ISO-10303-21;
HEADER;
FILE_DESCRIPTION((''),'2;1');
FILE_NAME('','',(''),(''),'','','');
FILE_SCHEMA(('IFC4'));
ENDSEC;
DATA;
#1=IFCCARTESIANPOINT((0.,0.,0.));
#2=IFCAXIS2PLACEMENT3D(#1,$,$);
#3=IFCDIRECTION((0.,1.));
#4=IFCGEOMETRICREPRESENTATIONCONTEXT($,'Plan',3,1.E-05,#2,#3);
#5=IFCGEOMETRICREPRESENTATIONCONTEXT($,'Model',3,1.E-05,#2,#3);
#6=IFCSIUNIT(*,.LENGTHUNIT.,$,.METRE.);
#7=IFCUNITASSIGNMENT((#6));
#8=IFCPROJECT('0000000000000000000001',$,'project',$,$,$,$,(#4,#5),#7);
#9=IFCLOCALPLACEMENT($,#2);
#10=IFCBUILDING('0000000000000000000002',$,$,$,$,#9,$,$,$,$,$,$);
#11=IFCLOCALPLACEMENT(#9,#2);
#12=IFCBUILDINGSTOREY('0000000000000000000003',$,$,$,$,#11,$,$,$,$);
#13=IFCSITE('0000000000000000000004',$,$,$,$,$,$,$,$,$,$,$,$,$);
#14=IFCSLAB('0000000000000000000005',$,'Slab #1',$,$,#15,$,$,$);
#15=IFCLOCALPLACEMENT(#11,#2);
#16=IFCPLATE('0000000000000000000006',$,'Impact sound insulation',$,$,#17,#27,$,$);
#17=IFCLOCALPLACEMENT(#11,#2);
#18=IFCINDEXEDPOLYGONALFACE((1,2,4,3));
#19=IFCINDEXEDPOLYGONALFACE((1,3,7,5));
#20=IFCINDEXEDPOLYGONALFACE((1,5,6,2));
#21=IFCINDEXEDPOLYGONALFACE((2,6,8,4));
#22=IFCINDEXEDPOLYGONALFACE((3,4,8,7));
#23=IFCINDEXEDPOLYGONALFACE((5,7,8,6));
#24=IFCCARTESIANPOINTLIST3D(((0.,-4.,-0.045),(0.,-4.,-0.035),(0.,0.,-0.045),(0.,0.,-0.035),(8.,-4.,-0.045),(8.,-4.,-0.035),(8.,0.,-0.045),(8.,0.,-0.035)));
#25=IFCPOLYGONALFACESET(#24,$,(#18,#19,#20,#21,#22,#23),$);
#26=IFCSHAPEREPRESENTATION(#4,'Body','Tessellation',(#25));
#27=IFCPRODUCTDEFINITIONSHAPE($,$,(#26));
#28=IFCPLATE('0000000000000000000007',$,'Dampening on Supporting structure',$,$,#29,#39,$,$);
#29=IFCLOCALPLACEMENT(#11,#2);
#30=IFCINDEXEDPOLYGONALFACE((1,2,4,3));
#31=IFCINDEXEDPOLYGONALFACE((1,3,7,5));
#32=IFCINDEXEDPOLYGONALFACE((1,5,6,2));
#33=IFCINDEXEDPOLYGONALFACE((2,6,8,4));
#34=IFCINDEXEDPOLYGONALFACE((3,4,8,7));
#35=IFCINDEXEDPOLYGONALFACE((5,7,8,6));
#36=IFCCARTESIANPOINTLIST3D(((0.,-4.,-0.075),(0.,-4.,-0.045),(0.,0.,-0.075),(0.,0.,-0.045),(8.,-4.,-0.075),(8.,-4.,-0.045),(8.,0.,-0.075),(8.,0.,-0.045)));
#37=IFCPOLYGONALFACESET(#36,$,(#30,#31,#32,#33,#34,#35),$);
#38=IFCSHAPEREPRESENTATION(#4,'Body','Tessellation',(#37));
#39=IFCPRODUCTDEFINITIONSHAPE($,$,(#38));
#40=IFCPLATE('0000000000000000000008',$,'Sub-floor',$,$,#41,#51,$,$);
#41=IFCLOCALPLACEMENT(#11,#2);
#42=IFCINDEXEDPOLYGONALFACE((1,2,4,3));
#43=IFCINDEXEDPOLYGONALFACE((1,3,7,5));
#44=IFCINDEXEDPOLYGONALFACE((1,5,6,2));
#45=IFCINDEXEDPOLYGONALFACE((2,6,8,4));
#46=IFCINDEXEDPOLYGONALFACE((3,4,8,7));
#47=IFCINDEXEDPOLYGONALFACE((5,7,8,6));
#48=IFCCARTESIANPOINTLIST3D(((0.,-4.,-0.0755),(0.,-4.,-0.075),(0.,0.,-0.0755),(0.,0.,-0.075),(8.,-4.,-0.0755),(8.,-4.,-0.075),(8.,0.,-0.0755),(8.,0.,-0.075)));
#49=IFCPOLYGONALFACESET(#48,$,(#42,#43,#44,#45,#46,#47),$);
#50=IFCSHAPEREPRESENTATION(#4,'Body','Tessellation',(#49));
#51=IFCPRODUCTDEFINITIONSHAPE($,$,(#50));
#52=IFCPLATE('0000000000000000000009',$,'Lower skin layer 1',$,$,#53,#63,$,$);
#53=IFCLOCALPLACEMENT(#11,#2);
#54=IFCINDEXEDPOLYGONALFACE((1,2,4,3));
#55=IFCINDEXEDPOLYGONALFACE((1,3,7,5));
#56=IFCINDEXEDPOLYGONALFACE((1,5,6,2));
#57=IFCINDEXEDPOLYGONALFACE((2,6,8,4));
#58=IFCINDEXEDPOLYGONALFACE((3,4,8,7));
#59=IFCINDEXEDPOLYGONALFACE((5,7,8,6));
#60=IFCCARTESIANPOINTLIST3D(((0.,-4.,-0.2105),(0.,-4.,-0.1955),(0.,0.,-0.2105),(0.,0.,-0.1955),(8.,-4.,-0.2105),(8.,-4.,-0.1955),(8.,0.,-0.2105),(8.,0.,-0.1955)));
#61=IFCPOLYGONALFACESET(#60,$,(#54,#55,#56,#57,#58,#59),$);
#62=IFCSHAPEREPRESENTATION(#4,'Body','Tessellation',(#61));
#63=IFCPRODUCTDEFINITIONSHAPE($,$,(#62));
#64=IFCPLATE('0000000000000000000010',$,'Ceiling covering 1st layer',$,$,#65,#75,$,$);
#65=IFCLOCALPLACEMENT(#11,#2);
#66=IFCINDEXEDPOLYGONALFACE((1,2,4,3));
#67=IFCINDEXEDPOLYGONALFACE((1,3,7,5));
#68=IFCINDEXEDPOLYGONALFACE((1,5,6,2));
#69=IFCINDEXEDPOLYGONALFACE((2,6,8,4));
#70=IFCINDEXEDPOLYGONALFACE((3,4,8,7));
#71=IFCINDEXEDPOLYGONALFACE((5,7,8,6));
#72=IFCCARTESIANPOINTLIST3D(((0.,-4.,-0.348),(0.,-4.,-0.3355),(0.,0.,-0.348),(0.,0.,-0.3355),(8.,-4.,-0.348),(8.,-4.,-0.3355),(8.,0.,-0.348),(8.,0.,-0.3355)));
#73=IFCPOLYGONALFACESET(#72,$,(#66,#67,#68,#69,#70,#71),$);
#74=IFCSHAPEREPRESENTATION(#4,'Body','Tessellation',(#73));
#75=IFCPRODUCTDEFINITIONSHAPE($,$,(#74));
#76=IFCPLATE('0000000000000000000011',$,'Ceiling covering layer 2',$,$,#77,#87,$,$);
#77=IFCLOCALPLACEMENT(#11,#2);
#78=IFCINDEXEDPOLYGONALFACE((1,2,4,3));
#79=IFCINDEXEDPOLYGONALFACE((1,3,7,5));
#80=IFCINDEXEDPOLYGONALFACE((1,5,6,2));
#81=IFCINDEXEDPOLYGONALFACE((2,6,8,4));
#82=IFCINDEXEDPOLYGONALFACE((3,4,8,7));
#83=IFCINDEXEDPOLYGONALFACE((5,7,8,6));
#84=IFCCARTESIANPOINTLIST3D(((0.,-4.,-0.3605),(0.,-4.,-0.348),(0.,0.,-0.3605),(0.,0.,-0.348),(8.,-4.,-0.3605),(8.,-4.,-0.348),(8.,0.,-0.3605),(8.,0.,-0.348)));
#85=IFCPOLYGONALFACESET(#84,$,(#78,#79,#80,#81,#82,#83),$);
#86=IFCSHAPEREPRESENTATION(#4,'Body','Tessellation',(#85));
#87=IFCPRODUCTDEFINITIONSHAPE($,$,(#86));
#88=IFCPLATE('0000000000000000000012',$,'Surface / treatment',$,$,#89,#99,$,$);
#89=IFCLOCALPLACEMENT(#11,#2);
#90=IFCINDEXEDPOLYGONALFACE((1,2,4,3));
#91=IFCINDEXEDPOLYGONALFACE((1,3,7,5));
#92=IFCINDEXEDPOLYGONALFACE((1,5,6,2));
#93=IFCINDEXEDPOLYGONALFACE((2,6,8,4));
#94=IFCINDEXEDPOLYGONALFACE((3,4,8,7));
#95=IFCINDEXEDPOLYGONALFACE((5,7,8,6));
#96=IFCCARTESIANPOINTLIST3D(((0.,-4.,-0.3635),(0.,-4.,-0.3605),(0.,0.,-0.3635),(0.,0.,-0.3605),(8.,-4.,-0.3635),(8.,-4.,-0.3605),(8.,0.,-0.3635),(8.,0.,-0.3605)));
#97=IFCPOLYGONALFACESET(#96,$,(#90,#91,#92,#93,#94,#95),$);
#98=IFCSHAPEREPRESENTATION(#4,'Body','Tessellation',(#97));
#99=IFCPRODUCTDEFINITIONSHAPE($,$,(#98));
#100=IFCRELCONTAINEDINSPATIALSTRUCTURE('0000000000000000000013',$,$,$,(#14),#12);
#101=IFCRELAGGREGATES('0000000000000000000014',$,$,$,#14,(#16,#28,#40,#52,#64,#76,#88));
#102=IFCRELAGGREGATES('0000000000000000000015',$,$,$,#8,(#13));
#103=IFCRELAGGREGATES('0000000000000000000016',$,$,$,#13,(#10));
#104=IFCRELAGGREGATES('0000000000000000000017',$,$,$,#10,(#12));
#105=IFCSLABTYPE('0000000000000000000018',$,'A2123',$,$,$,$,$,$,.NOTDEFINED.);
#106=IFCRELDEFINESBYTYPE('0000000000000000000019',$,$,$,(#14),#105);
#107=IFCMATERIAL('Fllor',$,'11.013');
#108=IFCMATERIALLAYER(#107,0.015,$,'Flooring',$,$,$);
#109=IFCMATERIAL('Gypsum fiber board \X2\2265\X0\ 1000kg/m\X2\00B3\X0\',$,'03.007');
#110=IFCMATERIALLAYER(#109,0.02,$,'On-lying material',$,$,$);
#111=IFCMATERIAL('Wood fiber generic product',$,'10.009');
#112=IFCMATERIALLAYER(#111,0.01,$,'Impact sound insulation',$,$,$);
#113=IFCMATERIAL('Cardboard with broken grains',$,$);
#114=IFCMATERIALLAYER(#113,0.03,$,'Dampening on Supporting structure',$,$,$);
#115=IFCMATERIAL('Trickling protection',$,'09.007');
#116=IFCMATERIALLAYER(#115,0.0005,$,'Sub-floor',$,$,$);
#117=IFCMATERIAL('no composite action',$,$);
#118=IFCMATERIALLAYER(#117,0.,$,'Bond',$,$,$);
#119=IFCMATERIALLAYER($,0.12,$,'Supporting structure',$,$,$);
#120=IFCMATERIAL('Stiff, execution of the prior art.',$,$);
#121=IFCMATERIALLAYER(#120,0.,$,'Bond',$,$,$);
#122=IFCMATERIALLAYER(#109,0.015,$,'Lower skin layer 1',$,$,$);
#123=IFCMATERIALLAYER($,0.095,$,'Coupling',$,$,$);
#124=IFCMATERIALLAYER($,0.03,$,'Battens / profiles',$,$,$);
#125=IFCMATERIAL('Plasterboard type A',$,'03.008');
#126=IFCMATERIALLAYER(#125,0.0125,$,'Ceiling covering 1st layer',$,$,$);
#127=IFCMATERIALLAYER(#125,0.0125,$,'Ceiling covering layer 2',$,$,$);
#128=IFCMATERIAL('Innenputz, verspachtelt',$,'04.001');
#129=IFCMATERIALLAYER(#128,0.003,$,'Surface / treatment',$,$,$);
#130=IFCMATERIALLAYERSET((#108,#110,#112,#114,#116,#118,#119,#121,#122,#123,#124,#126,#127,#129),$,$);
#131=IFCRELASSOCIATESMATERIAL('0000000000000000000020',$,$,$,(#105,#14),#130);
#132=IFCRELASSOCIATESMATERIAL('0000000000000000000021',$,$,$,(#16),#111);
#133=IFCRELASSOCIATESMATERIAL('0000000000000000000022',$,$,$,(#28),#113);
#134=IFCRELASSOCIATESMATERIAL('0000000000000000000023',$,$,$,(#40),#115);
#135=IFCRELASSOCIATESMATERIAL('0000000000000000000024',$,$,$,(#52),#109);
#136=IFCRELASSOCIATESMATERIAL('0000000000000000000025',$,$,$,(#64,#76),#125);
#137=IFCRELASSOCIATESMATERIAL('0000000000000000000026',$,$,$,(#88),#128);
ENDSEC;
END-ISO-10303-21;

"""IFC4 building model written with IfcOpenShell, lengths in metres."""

from ifc_helpers import new_model, si_unit, direction, frame, frame_2d, origin, place, context, project, spatial, rectangle, extrude, material, layer, layer_set, type_object, element, aggregate, save


model = new_model("IFC4")

# Units and contexts
plan_context = context("Plan", 3, precision=1e-05, world=origin(), true_north=direction((0.0, 1.0)))
model_context = context("Model", 3, precision=1e-05, world=origin(), true_north=direction((0.0, 1.0)))
ifc_project = project(units=[si_unit("LENGTHUNIT", "METRE")], contexts=[plan_context, model_context])

# Site, building, storey
site = spatial("IfcSite", under=ifc_project)
building_placement = place(None, origin())
building = spatial("IfcBuilding", under=site, at=building_placement)
storey_placement = place(building_placement, origin())
storey = spatial("IfcBuildingStorey", under=building, at=storey_placement)

# Slab, plates
ifc_material_1 = material(Name="Fllor", Category="11.013")
ifc_layer_1 = layer(ifc_material_1, 0.015, Name="Flooring")
ifc_material_2 = material(Name="Gypsum fiber board ≥ 1000kg/m³", Category="03.007")
ifc_layer_2 = layer(ifc_material_2, 0.02, Name="On-lying material")
ifc_material_3 = material(Name="Wood fiber generic product", Category="10.009")
ifc_layer_3 = layer(ifc_material_3, 0.01, Name="Impact sound insulation")
ifc_material_4 = material(Name="Cardboard with broken grains")
ifc_layer_4 = layer(ifc_material_4, 0.03, Name="Dampening on Supporting structure")
ifc_material_5 = material(Name="Trickling protection", Category="09.007")
ifc_layer_5 = layer(ifc_material_5, 0.0005, Name="Sub-floor")
ifc_material_6 = material(Name="no composite action")
ifc_layer_6 = layer(ifc_material_6, 0.0, Name="Bond")
ifc_layer_7 = layer(None, 0.12, Name="Supporting structure")
ifc_material_7 = material(Name="Stiff, execution of the prior art.")
ifc_layer_8 = layer(ifc_material_7, 0.0, Name="Bond")
ifc_layer_9 = layer(ifc_material_2, 0.015, Name="Lower skin layer 1")
ifc_layer_10 = layer(None, 0.095, Name="Coupling")
ifc_layer_11 = layer(None, 0.03, Name="Battens / profiles")
ifc_material_8 = material(Name="Plasterboard type A", Category="03.008")
ifc_layer_12 = layer(ifc_material_8, 0.0125, Name="Ceiling covering 1st layer")
ifc_layer_13 = layer(ifc_material_8, 0.0125, Name="Ceiling covering layer 2")
ifc_material_9 = material(Name="Innenputz, verspachtelt", Category="04.001")
ifc_layer_14 = layer(ifc_material_9, 0.003, Name="Surface / treatment")
ifc_layer_set = layer_set([ifc_layer_1, ifc_layer_2, ifc_layer_3, ifc_layer_4, ifc_layer_5, ifc_layer_6, ifc_layer_7, ifc_layer_8, ifc_layer_9, ifc_layer_10, ifc_layer_11, ifc_layer_12, ifc_layer_13, ifc_layer_14])
slab_type = type_object("IfcSlabType", Name="A2123", PredefinedType="NOTDEFINED", material=ifc_layer_set)
slab_placement = place(None, frame((0.0, 0.0, 0.0), z_axis=(0.0, 0.0, -1.0), x_axis=(1.0, 0.0, 0.0)))
slab = element("IfcSlab", 1, at=slab_placement, inside=storey, type_object=slab_type, material=ifc_layer_set, Name="Slab #1")
plate_1_placement = place(slab_placement, origin())
plate_1 = element("IfcPlate", 2, at=plate_1_placement, material=ifc_material_3, Name="Impact sound insulation", context=plan_context, shape_type="SweptSolid", body=[
    extrude(rectangle(XDim=8.0, YDim=4.0, at=frame_2d((4.0, 2.0), x_axis=(1.0, 0.0))), frame((0.0, 0.0, 0.035), z_axis=(0.0, 0.0, 1.0), x_axis=(1.0, 0.0, 0.0)), (0.0, 0.0, 1.0), 0.01),
])
plate_2_placement = place(slab_placement, origin())
plate_2 = element("IfcPlate", 3, at=plate_2_placement, material=ifc_material_4, Name="Dampening on Supporting structure", context=plan_context, shape_type="SweptSolid", body=[
    extrude(rectangle(XDim=8.0, YDim=4.0, at=frame_2d((4.0, 2.0), x_axis=(1.0, 0.0))), frame((0.0, 0.0, 0.045), z_axis=(0.0, 0.0, 1.0), x_axis=(1.0, 0.0, 0.0)), (0.0, 0.0, 1.0), 0.03),
])
plate_3_placement = place(slab_placement, origin())
plate_3 = element("IfcPlate", 4, at=plate_3_placement, material=ifc_material_5, Name="Sub-floor", context=plan_context, shape_type="SweptSolid", body=[
    extrude(rectangle(XDim=8.0, YDim=4.0, at=frame_2d((4.0, 2.0), x_axis=(1.0, 0.0))), frame((0.0, 0.0, 0.075), z_axis=(0.0, 0.0, 1.0), x_axis=(1.0, 0.0, 0.0)), (0.0, 0.0, 1.0), 0.0005),
])
plate_4_placement = place(slab_placement, origin())
plate_4 = element("IfcPlate", 5, at=plate_4_placement, material=ifc_material_2, Name="Lower skin layer 1", context=plan_context, shape_type="SweptSolid", body=[
    extrude(rectangle(XDim=8.0, YDim=4.0, at=frame_2d((4.0, 2.0), x_axis=(1.0, 0.0))), frame((0.0, 0.0, 0.1955), z_axis=(0.0, 0.0, 1.0), x_axis=(1.0, 0.0, 0.0)), (0.0, 0.0, 1.0), 0.015),
])
plate_5_placement = place(slab_placement, origin())
plate_5 = element("IfcPlate", 6, at=plate_5_placement, material=ifc_material_8, Name="Ceiling covering 1st layer", context=plan_context, shape_type="SweptSolid", body=[
    extrude(rectangle(XDim=8.0, YDim=4.0, at=frame_2d((4.0, 2.0), x_axis=(1.0, 0.0))), frame((0.0, 0.0, 0.3355), z_axis=(0.0, 0.0, 1.0), x_axis=(1.0, 0.0, 0.0)), (0.0, 0.0, 1.0), 0.0125),
])
plate_6_placement = place(slab_placement, origin())
plate_6 = element("IfcPlate", 7, at=plate_6_placement, material=ifc_material_8, Name="Ceiling covering layer 2", context=plan_context, shape_type="SweptSolid", body=[
    extrude(rectangle(XDim=8.0, YDim=4.0, at=frame_2d((4.0, 2.0), x_axis=(1.0, 0.0))), frame((0.0, 0.0, 0.348), z_axis=(0.0, 0.0, 1.0), x_axis=(1.0, 0.0, 0.0)), (0.0, 0.0, 1.0), 0.0125),
])
plate_7_placement = place(slab_placement, origin())
plate_7 = element("IfcPlate", 8, at=plate_7_placement, material=ifc_material_9, Name="Surface / treatment", context=plan_context, shape_type="SweptSolid", body=[
    extrude(rectangle(XDim=8.0, YDim=4.0, at=frame_2d((4.0, 2.0), x_axis=(1.0, 0.0))), frame((0.0, 0.0, 0.3605), z_axis=(0.0, 0.0, 1.0), x_axis=(1.0, 0.0, 0.0)), (0.0, 0.0, 1.0), 0.003),
])
aggregate(slab, [plate_1, plate_2, plate_3, plate_4, plate_5, plate_6, plate_7])

save(model, "model.ifc")
